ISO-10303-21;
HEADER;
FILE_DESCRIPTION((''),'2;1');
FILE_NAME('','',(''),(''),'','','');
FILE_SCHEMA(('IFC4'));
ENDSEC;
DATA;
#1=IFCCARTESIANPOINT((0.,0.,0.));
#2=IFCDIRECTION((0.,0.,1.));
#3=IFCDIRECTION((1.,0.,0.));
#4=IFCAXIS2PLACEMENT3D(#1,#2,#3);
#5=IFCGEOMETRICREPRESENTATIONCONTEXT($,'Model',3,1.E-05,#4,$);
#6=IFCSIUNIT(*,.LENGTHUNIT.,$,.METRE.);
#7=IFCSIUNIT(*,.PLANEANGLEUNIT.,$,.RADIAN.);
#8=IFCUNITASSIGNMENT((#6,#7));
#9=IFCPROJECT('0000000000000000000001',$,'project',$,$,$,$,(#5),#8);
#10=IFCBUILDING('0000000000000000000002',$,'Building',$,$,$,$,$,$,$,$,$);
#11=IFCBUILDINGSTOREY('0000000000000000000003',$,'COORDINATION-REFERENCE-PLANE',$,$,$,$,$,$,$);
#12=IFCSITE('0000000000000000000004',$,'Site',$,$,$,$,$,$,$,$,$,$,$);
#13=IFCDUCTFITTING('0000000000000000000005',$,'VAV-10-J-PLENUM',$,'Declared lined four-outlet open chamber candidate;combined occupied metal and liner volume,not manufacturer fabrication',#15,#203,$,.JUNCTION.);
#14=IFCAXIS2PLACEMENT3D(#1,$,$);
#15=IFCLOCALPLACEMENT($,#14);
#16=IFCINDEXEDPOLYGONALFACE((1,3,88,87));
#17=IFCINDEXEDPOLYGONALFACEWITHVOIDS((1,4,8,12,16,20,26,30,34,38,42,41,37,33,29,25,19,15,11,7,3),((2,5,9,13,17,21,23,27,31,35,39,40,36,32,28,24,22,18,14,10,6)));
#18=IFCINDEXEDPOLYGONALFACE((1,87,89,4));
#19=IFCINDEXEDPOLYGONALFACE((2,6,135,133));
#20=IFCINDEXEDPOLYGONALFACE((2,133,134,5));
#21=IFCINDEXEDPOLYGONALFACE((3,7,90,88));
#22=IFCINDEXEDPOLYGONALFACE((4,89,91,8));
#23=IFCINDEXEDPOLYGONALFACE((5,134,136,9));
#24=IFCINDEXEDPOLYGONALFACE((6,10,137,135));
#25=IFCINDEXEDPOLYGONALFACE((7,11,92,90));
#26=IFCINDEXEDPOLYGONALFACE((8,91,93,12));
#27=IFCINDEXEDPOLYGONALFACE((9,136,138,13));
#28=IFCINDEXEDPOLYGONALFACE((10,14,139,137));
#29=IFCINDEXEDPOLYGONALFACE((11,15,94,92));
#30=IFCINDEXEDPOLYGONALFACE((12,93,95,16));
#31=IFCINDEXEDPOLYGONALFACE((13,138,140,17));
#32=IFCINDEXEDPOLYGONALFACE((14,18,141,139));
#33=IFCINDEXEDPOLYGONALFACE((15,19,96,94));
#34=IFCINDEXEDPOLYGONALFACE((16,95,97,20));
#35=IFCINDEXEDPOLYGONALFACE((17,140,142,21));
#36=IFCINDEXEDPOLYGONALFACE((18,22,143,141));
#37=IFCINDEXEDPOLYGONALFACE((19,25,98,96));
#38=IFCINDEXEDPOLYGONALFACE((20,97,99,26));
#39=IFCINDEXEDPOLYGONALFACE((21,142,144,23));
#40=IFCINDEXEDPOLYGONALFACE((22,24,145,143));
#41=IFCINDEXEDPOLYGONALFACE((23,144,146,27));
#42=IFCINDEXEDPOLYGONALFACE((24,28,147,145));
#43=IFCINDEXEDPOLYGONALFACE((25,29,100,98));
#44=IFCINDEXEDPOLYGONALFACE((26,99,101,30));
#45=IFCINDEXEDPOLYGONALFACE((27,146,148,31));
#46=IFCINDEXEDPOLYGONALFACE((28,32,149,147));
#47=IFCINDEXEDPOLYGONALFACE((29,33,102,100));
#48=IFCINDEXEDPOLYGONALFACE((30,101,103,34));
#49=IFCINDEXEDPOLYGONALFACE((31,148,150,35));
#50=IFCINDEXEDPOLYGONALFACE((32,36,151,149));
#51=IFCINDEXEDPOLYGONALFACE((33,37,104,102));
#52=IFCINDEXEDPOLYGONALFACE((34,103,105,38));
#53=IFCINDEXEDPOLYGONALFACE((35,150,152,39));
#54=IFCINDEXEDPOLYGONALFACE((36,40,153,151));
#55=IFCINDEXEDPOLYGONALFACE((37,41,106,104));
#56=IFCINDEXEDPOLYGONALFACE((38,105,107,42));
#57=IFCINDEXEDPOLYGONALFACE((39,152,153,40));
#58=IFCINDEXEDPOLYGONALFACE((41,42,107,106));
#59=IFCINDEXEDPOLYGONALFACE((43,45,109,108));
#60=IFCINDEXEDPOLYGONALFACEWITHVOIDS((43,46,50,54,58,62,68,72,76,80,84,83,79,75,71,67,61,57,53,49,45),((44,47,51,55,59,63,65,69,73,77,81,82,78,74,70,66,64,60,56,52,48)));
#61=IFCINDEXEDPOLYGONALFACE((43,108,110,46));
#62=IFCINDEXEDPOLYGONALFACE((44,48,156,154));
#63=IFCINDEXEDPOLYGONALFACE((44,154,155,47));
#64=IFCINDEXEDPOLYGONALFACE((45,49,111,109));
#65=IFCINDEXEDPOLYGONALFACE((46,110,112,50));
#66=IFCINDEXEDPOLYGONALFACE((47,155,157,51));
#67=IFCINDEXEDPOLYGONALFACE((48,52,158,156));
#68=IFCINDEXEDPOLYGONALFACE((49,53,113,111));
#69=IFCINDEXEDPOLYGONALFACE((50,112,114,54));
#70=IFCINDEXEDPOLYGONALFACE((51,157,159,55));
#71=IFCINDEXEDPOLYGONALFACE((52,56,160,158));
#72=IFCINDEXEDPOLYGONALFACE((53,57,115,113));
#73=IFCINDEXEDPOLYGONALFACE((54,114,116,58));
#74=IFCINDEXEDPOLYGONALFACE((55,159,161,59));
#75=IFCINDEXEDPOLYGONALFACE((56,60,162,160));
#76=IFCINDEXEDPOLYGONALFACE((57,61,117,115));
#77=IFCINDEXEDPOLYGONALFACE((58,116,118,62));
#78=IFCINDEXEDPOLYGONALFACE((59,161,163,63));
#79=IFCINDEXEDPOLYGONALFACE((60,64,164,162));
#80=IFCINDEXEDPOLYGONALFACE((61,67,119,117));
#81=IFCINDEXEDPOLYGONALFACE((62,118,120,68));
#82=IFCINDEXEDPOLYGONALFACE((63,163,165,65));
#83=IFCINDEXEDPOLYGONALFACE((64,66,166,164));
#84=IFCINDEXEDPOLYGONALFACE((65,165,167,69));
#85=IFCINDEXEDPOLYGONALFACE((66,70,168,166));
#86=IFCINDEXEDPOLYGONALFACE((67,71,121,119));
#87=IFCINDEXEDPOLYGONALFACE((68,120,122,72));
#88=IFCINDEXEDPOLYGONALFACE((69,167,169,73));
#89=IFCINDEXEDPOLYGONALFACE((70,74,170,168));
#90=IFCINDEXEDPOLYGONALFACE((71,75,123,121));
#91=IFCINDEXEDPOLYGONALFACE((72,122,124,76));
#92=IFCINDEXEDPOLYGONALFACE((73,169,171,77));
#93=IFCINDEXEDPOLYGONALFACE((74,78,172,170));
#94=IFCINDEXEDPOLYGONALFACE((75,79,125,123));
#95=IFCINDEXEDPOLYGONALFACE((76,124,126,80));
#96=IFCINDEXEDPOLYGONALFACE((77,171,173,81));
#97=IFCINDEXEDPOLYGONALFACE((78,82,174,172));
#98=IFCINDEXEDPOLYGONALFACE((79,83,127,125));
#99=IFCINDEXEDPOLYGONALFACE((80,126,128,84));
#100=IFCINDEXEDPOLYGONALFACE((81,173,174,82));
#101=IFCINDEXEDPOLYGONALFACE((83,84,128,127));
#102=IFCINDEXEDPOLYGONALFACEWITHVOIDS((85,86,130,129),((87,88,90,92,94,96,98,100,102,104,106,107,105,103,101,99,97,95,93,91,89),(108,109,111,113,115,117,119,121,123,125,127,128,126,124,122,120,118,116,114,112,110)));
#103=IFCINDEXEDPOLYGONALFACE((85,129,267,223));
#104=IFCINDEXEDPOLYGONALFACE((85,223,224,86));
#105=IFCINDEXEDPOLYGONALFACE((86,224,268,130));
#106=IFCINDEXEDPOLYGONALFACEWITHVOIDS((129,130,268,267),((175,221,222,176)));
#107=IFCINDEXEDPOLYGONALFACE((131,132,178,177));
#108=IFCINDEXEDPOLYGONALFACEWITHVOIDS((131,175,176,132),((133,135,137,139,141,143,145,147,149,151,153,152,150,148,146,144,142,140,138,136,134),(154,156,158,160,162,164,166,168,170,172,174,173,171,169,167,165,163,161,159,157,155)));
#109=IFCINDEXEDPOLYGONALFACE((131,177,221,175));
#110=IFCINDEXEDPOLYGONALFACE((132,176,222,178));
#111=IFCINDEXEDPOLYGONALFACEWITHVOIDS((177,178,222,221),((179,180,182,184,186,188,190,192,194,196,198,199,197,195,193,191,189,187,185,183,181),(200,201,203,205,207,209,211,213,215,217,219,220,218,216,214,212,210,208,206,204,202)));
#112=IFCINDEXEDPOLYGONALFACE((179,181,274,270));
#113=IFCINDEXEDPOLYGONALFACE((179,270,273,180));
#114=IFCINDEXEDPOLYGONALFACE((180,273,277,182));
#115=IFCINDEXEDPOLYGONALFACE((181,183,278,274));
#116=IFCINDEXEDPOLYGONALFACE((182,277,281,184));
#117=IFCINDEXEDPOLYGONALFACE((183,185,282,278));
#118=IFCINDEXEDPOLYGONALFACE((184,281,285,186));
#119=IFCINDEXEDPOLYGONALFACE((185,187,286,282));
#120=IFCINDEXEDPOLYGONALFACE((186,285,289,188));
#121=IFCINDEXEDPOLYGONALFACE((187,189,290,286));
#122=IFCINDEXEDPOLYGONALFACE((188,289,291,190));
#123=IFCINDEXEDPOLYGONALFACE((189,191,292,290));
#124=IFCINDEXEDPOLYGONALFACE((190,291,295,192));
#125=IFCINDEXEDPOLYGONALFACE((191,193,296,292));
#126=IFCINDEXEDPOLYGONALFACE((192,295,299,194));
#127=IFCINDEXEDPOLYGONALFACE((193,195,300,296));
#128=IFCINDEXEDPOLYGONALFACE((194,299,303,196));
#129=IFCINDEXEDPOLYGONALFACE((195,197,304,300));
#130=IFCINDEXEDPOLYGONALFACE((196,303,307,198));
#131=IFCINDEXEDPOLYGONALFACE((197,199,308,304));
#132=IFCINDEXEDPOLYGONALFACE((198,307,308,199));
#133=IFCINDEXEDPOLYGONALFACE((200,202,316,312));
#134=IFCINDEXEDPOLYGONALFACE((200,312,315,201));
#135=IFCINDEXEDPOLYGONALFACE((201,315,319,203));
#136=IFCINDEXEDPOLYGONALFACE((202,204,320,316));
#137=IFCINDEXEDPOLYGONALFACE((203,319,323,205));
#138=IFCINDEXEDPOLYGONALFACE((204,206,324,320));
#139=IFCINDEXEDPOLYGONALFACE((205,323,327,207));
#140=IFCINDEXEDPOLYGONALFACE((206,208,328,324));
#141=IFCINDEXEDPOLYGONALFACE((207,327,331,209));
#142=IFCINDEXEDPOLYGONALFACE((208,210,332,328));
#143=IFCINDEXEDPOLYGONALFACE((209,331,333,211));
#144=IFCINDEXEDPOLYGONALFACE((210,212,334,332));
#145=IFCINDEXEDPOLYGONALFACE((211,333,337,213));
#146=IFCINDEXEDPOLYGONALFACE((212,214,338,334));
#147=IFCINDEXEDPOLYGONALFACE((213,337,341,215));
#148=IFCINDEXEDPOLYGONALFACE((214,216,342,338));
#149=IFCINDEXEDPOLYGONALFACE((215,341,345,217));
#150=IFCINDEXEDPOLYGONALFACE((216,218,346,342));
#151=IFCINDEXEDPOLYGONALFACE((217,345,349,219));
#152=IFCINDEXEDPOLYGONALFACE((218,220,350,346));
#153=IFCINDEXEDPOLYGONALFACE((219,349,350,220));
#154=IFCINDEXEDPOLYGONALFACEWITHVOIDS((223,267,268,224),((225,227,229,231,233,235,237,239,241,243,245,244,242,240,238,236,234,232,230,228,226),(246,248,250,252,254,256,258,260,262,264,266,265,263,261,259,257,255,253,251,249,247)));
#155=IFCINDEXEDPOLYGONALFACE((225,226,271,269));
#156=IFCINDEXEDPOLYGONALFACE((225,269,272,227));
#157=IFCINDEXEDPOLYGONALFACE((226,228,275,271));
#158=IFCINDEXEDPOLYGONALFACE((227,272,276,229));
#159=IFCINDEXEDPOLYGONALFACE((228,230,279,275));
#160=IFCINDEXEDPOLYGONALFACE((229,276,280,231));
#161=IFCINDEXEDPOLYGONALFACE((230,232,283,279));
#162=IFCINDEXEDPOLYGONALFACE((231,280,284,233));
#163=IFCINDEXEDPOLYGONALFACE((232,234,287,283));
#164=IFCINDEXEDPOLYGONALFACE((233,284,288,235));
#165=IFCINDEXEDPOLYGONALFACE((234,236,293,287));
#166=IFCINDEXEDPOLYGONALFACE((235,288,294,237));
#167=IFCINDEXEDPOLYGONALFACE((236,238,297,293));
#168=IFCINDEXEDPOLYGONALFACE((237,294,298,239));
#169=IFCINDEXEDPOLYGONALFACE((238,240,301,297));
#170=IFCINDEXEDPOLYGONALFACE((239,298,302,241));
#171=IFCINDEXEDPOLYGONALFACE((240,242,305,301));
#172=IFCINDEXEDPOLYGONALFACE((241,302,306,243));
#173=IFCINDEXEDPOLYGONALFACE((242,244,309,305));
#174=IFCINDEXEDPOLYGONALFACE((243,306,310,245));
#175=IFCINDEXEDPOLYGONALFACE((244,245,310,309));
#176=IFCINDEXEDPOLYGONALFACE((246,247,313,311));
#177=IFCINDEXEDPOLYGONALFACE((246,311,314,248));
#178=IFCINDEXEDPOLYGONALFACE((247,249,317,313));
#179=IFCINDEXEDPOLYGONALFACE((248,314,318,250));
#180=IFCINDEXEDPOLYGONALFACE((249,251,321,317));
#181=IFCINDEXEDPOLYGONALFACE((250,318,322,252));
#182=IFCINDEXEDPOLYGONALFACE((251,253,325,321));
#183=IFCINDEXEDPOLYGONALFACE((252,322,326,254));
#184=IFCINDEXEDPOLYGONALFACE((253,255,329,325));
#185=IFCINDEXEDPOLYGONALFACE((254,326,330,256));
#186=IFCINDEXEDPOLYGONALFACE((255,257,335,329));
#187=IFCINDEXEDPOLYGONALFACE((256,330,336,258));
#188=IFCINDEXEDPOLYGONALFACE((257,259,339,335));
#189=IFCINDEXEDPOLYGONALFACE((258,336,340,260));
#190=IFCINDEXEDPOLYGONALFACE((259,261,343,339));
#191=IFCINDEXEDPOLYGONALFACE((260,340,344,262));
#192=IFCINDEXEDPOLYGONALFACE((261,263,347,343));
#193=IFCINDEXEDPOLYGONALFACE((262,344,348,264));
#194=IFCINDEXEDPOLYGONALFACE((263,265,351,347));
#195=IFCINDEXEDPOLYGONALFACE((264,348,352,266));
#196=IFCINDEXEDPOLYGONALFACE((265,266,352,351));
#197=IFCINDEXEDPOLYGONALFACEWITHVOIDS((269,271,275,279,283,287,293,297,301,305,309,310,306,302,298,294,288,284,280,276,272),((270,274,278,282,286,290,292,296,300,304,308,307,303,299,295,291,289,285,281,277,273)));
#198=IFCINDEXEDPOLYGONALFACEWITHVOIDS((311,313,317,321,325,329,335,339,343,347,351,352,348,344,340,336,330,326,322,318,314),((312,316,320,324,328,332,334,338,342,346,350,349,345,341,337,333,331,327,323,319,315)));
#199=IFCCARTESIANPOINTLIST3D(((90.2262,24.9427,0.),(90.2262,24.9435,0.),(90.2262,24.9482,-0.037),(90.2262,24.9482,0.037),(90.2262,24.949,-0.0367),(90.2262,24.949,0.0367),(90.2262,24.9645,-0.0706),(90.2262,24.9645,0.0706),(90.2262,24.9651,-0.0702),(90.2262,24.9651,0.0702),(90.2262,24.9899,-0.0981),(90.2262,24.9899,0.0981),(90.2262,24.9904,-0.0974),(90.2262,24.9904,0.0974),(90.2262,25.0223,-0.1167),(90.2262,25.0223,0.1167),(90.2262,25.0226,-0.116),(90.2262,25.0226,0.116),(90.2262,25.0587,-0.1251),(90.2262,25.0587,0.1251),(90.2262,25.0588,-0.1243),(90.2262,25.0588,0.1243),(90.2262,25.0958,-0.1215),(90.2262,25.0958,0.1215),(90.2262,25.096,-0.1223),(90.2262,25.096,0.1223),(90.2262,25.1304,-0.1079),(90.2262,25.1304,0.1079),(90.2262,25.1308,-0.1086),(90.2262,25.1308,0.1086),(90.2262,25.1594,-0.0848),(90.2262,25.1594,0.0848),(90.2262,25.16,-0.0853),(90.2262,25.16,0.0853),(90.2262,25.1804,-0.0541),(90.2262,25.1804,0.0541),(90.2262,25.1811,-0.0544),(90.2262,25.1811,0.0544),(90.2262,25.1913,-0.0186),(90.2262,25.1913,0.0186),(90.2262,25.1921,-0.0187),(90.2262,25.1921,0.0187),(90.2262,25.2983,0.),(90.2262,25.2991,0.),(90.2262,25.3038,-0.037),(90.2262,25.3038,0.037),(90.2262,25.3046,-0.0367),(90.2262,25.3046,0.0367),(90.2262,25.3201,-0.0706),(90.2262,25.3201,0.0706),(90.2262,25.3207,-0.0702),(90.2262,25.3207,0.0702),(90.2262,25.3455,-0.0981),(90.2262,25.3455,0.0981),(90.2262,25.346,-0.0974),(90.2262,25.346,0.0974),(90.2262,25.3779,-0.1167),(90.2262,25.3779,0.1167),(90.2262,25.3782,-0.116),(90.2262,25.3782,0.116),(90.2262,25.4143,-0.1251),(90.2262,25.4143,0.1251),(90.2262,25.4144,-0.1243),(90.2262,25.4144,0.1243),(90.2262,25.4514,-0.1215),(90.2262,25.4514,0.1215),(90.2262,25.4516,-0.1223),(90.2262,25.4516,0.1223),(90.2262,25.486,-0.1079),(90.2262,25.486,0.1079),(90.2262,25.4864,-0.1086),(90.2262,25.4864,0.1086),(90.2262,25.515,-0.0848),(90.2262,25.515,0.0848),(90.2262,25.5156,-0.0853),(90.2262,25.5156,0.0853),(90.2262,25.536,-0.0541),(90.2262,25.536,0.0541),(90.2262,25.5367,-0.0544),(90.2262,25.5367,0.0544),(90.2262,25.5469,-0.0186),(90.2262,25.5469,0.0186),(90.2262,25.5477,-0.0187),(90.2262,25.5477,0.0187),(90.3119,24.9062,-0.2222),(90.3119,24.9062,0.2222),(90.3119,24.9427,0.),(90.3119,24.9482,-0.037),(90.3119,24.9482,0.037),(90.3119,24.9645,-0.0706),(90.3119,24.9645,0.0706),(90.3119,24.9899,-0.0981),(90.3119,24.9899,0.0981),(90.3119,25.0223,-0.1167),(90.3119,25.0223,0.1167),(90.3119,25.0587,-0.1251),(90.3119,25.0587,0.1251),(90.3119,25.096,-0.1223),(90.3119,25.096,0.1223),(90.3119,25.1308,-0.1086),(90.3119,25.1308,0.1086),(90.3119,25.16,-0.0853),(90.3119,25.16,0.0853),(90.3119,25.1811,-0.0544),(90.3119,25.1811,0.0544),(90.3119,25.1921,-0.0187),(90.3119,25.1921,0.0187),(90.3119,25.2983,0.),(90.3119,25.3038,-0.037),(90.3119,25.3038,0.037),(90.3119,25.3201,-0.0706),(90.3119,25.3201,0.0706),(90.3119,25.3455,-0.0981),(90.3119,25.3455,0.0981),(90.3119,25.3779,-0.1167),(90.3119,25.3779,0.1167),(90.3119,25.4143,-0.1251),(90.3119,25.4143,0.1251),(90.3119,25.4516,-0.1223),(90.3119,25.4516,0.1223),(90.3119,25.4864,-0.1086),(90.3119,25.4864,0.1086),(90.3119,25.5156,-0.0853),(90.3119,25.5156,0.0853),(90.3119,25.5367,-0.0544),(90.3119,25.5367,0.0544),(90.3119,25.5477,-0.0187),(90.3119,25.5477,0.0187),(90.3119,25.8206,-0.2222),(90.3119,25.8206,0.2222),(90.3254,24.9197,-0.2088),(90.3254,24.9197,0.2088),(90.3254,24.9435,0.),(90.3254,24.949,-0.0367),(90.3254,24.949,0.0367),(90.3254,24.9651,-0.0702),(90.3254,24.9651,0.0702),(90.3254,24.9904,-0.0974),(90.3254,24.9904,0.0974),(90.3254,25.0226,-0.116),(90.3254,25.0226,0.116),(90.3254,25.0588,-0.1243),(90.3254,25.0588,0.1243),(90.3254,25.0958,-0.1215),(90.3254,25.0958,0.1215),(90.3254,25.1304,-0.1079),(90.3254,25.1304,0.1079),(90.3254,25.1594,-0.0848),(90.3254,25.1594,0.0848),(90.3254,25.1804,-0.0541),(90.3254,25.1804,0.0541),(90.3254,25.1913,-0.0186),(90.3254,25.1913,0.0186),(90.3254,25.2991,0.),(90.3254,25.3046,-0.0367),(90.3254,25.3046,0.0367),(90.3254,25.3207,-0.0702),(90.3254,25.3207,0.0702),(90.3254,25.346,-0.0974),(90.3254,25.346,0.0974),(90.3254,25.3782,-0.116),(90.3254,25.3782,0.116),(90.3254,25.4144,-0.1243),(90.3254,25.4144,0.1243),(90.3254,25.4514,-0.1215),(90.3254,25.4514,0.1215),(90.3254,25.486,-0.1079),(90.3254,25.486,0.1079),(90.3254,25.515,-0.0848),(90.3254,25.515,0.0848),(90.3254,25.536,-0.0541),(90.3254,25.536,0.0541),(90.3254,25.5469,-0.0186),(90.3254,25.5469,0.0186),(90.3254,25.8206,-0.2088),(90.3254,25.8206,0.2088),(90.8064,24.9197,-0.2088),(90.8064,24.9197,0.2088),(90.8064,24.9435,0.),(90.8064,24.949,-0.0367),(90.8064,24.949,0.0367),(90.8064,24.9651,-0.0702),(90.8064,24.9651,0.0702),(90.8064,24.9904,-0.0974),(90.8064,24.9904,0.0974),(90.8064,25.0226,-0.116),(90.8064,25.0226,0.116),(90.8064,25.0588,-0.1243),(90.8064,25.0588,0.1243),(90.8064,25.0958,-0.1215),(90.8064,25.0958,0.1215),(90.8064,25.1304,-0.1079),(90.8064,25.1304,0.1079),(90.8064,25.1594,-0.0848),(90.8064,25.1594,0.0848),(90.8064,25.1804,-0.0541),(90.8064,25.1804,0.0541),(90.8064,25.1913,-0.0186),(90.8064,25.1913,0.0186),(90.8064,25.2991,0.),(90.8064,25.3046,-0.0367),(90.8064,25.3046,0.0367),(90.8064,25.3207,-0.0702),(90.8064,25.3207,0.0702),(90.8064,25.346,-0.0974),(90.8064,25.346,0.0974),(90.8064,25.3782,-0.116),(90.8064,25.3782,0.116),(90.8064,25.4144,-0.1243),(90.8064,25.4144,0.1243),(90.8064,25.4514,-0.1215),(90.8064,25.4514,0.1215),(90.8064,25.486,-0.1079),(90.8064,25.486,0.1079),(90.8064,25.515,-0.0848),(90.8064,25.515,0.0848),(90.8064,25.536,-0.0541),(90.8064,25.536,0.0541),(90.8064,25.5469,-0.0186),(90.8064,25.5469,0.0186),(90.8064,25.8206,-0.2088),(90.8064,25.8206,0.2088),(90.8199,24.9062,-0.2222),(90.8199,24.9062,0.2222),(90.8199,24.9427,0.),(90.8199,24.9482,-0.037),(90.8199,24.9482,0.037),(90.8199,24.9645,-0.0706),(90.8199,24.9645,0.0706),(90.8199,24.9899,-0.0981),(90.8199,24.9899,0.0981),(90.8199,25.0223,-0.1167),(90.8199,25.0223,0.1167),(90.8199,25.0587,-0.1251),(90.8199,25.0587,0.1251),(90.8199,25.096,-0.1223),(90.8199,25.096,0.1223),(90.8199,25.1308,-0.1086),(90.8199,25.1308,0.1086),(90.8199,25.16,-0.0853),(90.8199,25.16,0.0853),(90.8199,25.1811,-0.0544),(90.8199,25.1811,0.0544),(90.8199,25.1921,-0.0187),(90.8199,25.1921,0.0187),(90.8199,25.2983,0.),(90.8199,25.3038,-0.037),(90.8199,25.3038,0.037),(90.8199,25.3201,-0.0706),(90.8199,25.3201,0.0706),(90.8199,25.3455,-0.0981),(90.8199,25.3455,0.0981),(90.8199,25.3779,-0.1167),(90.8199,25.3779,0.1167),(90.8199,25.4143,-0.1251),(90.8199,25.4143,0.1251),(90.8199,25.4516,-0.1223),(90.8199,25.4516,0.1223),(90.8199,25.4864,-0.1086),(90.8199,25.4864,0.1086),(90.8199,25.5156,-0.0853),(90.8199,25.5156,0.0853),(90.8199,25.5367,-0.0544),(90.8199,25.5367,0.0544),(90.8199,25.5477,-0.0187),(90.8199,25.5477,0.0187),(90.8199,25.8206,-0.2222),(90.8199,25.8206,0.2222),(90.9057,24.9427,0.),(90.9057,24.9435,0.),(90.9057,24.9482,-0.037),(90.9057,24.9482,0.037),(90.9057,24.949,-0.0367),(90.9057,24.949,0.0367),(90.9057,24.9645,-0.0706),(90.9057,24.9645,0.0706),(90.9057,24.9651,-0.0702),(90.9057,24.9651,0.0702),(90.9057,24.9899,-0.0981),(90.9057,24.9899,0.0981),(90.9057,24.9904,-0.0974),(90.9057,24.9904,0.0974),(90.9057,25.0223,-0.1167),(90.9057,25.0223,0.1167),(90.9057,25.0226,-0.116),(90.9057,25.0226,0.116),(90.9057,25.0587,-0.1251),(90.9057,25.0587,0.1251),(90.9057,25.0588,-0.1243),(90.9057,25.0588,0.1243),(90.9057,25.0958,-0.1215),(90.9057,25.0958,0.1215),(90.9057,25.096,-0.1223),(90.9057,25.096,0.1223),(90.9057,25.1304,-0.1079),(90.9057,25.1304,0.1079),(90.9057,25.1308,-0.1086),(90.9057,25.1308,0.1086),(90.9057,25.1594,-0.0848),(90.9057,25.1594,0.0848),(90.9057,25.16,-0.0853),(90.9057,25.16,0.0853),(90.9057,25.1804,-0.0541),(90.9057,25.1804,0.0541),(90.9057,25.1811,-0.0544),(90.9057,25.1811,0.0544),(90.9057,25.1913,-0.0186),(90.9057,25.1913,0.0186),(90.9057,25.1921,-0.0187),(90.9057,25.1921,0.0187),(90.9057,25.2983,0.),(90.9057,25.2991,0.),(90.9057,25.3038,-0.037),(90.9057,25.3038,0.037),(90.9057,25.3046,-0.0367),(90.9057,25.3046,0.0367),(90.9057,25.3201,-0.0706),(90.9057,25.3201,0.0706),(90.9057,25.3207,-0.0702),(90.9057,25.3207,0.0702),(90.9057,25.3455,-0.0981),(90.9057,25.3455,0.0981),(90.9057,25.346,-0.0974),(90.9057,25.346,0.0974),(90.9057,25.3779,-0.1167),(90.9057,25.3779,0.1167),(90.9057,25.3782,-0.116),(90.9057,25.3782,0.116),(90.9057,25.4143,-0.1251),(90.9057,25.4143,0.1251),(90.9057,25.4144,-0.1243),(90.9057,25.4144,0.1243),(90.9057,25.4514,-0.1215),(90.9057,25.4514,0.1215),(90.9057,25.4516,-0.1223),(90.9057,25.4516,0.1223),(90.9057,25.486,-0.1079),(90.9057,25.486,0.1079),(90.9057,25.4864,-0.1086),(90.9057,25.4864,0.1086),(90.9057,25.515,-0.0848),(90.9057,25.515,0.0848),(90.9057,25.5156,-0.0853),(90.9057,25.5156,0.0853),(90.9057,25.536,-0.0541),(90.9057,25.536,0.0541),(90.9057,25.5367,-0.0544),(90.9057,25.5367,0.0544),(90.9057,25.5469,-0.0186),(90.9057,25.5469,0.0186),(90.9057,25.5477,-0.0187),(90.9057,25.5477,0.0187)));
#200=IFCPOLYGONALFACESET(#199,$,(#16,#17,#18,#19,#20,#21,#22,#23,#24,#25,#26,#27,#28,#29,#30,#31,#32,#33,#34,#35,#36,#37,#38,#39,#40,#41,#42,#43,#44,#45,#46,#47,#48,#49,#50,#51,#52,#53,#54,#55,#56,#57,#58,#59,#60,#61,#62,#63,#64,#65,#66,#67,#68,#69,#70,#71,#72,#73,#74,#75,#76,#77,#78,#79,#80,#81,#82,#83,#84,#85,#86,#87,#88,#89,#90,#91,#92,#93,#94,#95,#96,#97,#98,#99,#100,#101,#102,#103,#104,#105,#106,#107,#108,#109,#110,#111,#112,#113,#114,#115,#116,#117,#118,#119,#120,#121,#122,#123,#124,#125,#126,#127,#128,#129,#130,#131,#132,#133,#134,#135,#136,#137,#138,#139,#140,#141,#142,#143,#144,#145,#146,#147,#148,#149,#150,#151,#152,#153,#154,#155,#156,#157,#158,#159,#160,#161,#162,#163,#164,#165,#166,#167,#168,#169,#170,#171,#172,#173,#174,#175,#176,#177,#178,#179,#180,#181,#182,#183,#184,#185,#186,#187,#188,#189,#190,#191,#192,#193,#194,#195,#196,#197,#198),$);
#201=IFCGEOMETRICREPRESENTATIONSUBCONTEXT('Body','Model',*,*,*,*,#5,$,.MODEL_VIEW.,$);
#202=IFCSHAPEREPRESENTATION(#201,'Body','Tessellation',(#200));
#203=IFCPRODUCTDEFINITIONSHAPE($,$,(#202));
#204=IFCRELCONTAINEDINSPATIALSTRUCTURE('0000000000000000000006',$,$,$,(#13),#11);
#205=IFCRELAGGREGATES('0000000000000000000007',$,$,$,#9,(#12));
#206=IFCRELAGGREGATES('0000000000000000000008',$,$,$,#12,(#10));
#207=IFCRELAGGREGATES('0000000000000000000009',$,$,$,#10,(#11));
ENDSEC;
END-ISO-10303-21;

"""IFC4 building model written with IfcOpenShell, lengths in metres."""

from ifc_helpers import new_model, si_unit, frame, origin_with_axes, place, context, subcontext, project, spatial, rectangle, circle, extrude, boolean, element, save


model = new_model("IFC4")

# Units and contexts
model_context = context("Model", 3, precision=1e-05, world=origin_with_axes())
body_context_1 = subcontext(model_context, "Body", "Model", "MODEL_VIEW")
ifc_project = project(units=[si_unit("LENGTHUNIT", "METRE"), si_unit("PLANEANGLEUNIT", "RADIAN")], contexts=[model_context])

# Site, building, storey
site = spatial("IfcSite", under=ifc_project, Name="Site")
building = spatial("IfcBuilding", under=site, Name="Building")
storey = spatial("IfcBuildingStorey", under=building, Name="COORDINATION-REFERENCE-PLANE")

# Duct fitting
duct_fitting_1_placement = place(None, frame((90.3119, 24.9062, -0.2223), z_axis=(0.0, 0.0, 1.0), x_axis=(1.0, 0.0, 0.0)))
solid_1 = boolean("UNION", boolean("UNION", boolean("UNION", boolean("UNION", extrude(rectangle(XDim=0.481, YDim=0.4175), frame((0.254, 0.9244, 0.2223), z_axis=(0.0, -1.0, 0.0), x_axis=(1.0, 0.0, 0.0)), (0.0, 0.0, 1.0), 0.9109), extrude(circle(Radius=0.1246), frame((0.0235, 0.5175, 0.2223), z_axis=(-1.0, 0.0, 0.0), x_axis=(0.0, -1.0, 0.0)), (0.0, 0.0, 1.0), 0.1192)), extrude(circle(Radius=0.1246), frame((0.4845, 0.5175, 0.2223), z_axis=(1.0, 0.0, 0.0), x_axis=(0.0, -1.0, 0.0)), (0.0, 0.0, 1.0), 0.1192)), extrude(circle(Radius=0.1246), frame((0.0235, 0.1619, 0.2223), z_axis=(-1.0, 0.0, 0.0), x_axis=(0.0, -1.0, 0.0)), (0.0, 0.0, 1.0), 0.1192)), extrude(circle(Radius=0.1246), frame((0.4845, 0.1619, 0.2223), z_axis=(1.0, 0.0, 0.0), x_axis=(0.0, -1.0, 0.0)), (0.0, 0.0, 1.0), 0.1192))
element("IfcDuctFitting", 1, at=duct_fitting_1_placement, inside=storey, Name="VAV-10-J-PLENUM", ObjectType="Declared lined four-outlet open chamber candidate;combined occupied metal and liner volume,not manufacturer fabrication", PredefinedType="JUNCTION", context=body_context_1, shape_type="CSG", body=[
    boolean("DIFFERENCE", boolean("UNION", boolean("UNION", boolean("UNION", boolean("UNION", extrude(rectangle(XDim=0.508, YDim=0.4445), frame((0.254, 0.9144, 0.2223), z_axis=(0.0, -1.0, 0.0), x_axis=(1.0, 0.0, 0.0)), (0.0, 0.0, 1.0), 0.9144), extrude(circle(Radius=0.1254), frame((0.0235, 0.5175, 0.2223), z_axis=(-1.0, 0.0, 0.0), x_axis=(0.0, -1.0, 0.0)), (0.0, 0.0, 1.0), 0.1092)), extrude(circle(Radius=0.1254), frame((0.4845, 0.5175, 0.2223), z_axis=(1.0, 0.0, 0.0), x_axis=(0.0, -1.0, 0.0)), (0.0, 0.0, 1.0), 0.1092)), extrude(circle(Radius=0.1254), frame((0.0235, 0.1619, 0.2223), z_axis=(-1.0, 0.0, 0.0), x_axis=(0.0, -1.0, 0.0)), (0.0, 0.0, 1.0), 0.1092)), extrude(circle(Radius=0.1254), frame((0.4845, 0.1619, 0.2223), z_axis=(1.0, 0.0, 0.0), x_axis=(0.0, -1.0, 0.0)), (0.0, 0.0, 1.0), 0.1092)), solid_1),
])

save(model, "model.ifc")
